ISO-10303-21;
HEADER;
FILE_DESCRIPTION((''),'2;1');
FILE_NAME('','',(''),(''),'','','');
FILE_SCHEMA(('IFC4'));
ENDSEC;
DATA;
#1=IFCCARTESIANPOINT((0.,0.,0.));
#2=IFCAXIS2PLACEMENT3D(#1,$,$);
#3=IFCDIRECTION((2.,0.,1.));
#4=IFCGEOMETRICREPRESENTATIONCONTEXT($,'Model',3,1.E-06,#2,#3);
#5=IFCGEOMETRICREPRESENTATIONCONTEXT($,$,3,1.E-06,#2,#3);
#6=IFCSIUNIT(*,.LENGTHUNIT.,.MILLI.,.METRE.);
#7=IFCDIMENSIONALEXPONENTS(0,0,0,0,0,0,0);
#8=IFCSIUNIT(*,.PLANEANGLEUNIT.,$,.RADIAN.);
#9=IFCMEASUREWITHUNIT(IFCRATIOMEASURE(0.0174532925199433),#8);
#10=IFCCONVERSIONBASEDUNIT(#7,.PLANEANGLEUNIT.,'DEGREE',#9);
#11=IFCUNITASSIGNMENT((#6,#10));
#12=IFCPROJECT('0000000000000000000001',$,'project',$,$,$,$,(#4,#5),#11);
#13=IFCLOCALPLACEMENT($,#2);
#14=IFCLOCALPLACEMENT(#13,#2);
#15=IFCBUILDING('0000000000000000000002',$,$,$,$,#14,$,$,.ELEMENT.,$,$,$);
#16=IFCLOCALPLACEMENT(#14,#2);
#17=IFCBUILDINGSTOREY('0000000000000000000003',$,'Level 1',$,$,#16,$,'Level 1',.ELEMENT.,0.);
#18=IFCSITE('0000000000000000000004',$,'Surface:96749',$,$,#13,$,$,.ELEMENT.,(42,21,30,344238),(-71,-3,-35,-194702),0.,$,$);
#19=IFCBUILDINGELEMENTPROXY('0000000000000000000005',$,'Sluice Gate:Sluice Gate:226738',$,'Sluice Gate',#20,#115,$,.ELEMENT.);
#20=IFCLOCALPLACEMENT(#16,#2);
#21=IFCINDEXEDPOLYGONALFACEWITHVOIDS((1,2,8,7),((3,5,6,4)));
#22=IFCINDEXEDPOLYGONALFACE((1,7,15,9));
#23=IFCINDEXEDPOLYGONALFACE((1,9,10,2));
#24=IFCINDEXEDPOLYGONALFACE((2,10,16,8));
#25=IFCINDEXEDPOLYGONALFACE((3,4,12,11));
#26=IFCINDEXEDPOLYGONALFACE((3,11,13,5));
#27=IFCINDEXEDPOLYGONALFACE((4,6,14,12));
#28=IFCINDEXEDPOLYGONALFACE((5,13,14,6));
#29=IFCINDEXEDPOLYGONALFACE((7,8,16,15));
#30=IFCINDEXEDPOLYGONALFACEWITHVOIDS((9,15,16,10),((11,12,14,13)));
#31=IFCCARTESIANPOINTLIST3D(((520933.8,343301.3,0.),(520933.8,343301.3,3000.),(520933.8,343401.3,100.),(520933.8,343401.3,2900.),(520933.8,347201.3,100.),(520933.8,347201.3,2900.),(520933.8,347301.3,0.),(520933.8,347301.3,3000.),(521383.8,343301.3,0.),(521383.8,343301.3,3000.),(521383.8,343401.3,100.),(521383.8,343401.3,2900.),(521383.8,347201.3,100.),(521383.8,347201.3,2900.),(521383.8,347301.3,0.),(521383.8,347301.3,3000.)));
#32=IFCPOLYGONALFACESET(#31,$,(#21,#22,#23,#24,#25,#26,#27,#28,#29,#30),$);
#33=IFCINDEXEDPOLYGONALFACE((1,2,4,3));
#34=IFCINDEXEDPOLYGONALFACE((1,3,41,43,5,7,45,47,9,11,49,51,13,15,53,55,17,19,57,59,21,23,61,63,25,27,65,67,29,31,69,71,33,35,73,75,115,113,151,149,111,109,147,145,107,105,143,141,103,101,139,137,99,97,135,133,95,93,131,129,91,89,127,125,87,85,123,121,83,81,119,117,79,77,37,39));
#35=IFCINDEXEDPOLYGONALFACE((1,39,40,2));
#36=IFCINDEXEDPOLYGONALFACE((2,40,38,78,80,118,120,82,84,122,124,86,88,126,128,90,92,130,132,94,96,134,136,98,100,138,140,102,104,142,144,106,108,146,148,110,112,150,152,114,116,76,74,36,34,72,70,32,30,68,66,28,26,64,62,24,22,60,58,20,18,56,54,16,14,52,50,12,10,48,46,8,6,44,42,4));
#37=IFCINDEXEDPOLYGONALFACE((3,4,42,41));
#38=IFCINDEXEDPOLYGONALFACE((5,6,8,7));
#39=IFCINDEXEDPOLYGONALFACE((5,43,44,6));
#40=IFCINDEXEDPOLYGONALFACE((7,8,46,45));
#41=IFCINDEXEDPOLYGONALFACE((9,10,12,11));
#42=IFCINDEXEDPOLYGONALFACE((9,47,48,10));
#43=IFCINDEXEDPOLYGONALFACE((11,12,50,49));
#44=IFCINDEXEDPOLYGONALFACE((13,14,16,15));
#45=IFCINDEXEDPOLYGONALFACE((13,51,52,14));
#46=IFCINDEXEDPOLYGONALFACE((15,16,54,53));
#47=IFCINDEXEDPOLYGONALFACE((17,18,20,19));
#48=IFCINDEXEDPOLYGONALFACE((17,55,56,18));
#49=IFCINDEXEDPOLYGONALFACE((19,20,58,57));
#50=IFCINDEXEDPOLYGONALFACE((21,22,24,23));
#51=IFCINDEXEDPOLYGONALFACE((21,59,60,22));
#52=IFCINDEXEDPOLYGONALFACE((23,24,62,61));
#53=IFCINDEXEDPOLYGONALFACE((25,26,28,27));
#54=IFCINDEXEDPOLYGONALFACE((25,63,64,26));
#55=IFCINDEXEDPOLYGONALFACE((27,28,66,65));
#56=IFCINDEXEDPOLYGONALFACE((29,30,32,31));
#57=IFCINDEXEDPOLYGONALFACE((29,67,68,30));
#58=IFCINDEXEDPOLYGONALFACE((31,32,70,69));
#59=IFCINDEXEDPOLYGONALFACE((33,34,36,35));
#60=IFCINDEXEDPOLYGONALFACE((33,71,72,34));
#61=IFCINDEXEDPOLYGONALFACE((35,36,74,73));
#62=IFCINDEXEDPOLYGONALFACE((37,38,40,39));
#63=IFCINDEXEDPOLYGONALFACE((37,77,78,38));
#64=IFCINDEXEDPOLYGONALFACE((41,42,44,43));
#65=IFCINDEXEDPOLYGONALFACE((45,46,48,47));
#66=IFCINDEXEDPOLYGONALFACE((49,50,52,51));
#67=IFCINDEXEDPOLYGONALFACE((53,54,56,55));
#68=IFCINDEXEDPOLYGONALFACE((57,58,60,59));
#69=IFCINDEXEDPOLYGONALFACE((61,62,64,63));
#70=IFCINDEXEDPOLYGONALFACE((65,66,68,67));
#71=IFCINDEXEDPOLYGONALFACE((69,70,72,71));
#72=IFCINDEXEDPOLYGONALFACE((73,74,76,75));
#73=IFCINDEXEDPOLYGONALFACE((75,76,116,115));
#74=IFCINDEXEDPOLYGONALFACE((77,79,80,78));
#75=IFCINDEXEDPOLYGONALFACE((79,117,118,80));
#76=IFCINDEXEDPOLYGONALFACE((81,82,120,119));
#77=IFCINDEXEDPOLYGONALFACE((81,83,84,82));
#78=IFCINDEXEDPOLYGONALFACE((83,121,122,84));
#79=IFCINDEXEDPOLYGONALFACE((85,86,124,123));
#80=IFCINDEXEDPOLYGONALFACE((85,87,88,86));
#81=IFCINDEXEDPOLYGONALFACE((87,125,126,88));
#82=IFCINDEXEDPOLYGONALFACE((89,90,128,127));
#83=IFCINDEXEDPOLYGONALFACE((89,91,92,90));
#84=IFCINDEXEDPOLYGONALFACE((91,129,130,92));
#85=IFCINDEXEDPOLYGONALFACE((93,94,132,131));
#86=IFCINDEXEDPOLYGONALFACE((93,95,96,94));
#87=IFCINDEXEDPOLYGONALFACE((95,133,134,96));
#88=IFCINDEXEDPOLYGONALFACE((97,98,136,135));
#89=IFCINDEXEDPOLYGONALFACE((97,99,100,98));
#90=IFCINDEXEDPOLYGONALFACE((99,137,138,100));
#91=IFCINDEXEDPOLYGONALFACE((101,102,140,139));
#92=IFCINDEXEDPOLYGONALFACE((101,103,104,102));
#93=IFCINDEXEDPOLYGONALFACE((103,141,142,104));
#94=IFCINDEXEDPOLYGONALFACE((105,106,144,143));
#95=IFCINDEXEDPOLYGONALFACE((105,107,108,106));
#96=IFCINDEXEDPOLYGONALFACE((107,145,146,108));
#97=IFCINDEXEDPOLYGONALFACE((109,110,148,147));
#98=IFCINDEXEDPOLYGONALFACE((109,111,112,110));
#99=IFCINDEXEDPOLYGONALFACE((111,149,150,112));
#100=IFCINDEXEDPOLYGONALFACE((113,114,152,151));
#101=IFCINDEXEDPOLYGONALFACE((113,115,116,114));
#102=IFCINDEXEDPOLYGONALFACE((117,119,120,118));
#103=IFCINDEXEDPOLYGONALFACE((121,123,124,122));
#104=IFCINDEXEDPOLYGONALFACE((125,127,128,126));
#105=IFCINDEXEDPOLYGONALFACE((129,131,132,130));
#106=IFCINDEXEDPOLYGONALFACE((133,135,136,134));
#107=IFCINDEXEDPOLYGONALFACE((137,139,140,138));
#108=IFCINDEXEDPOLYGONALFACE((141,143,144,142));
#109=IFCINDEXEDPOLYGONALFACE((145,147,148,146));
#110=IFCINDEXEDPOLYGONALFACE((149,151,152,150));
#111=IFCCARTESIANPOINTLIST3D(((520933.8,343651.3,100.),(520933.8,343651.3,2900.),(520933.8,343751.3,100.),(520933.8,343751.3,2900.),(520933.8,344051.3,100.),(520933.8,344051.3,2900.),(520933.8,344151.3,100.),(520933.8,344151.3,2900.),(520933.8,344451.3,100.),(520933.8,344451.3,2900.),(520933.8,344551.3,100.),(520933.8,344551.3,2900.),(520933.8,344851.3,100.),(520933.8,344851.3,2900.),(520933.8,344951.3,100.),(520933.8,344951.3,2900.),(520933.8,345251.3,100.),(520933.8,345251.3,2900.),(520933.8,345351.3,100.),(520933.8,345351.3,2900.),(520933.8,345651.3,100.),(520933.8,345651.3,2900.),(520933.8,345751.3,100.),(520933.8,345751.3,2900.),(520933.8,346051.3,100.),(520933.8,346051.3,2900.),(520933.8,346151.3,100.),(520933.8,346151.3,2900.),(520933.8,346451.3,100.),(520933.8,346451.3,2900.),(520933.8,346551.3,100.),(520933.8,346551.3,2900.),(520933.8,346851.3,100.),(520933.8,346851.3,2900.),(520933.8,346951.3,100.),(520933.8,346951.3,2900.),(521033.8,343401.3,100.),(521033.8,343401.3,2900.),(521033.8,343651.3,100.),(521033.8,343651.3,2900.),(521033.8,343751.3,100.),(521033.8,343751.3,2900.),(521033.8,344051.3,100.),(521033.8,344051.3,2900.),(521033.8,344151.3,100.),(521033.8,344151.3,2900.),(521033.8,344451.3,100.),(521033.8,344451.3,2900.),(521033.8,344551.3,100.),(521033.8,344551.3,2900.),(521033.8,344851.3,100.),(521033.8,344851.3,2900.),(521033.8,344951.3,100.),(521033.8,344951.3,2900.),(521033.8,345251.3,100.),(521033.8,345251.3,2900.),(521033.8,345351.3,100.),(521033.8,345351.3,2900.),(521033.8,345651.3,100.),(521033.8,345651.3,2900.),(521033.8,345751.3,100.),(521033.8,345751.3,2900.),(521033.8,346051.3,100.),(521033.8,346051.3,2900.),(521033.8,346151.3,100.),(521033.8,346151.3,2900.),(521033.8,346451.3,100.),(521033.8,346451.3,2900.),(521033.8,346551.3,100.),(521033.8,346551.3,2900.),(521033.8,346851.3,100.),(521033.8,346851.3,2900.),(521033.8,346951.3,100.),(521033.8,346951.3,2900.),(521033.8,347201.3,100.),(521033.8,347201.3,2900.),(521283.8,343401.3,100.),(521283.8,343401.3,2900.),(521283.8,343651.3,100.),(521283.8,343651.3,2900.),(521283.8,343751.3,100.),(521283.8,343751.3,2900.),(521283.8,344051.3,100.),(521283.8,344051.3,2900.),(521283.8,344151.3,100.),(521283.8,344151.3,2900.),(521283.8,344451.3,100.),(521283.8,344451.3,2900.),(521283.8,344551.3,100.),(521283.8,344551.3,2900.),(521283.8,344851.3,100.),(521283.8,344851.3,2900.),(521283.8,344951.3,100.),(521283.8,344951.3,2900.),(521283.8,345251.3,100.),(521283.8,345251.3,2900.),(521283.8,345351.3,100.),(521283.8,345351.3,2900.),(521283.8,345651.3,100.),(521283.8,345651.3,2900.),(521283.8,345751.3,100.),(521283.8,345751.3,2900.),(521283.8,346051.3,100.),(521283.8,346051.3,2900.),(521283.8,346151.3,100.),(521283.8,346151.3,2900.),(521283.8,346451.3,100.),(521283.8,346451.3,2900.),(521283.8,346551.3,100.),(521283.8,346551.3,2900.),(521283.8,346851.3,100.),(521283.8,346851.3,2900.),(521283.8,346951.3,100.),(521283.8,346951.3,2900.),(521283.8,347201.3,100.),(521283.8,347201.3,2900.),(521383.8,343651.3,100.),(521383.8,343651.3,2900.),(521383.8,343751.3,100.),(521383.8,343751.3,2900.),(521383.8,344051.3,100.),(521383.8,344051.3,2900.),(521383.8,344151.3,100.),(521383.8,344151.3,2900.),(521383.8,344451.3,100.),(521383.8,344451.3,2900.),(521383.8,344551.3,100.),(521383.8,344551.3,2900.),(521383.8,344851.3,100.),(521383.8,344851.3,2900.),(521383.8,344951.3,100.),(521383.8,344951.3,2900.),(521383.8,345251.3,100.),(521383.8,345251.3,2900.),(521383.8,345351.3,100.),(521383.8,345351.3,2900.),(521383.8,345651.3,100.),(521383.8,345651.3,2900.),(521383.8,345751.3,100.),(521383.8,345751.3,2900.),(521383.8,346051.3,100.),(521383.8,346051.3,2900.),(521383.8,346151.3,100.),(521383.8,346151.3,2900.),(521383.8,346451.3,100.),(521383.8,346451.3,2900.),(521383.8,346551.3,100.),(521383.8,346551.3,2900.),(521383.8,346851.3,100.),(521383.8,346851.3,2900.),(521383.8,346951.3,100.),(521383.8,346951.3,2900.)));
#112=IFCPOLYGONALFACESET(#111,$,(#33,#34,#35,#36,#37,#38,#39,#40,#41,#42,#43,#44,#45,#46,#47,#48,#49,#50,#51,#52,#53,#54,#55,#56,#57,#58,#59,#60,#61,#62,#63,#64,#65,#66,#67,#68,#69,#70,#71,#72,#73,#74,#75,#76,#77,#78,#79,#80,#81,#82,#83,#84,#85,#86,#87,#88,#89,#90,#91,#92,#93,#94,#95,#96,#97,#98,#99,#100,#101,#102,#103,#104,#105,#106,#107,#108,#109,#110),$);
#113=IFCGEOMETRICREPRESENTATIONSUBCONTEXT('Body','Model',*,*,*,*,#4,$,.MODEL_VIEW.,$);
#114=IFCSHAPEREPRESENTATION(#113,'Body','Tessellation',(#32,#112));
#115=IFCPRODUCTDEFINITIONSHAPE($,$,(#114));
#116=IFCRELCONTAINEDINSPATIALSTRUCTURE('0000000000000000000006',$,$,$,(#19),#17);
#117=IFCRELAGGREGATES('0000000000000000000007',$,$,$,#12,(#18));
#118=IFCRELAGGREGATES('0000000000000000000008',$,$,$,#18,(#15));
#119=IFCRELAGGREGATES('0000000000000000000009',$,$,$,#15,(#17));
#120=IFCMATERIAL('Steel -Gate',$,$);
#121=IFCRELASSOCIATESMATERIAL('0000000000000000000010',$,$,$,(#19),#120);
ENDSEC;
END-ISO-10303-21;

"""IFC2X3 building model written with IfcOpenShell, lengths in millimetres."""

from ifc_helpers import new_model, entity, si_unit, converted_unit, direction, frame, origin, place, context, subcontext, project, spatial, polyline, outline, extrude, source, transform, mapped, material, element, save


model = new_model("IFC2X3")

# Units and contexts
model_context = context("Model", 3, precision=1e-06, world=origin(), true_north=direction((2.0, 0.0, 1.0)))
context_of_model = context(None, 3, precision=1e-06, world=origin(), true_north=direction((2.0, 0.0, 1.0)))
body_context = subcontext(model_context, "Body", "Model", "MODEL_VIEW")
ifc_project = project(units=[si_unit("LENGTHUNIT", "METRE", prefix="MILLI"), converted_unit("PLANEANGLEUNIT", "DEGREE", entity("IfcRatioMeasure", 0.0174532925199433), si_unit("PLANEANGLEUNIT", "RADIAN"), dimensions=[0, 0, 0, 0, 0, 0, 0])], contexts=[model_context, context_of_model])

# Site, building, storey
site_placement = place(None, origin())
site = spatial("IfcSite", under=ifc_project, at=site_placement, Name="Surface:96749", CompositionType="ELEMENT", RefLatitude=(42, 21, 30, 344238), RefLongitude=(-71, -3, -35, -194702), RefElevation=0.0)
building_placement = place(site_placement, origin())
building = spatial("IfcBuilding", under=site, at=building_placement, CompositionType="ELEMENT")
storey_placement = place(building_placement, origin())
storey = spatial("IfcBuildingStorey", under=building, at=storey_placement, Name="Level 1", LongName="Level 1", CompositionType="ELEMENT", Elevation=0.0)

# Building element proxy
ifc_material = material(Name="Steel -Gate")
shared_shape_1 = source(origin(), body_context, "Body", "SweptSolid", [
    extrude(outline(polyline([(-1500.0, -2000.0), (1500.0, -2000.0), (1500.0, 2000.0), (-1500.0, 2000.0), (-1500.0, -2000.0)]), holes=[polyline([(1400.0, -1900.0), (-1400.0, -1900.0), (-1400.0, 1900.0), (1400.0, 1900.0), (1400.0, -1900.0)])]), frame((0.0, -225.0, 1500.0), z_axis=(0.0, 1.0, 0.0), x_axis=(0.0, 0.0, -1.0)), (0.0, 0.0, 1.0), 450.0),
    extrude(outline(polyline([(1650.0, -125.0), (1900.0, -125.0), (1900.0, 125.0), (1650.0, 125.0), (1650.0, 225.0), (1550.0, 225.0), (1550.0, 125.0), (1250.0, 125.0), (1250.0, 225.0), (1150.0, 225.0), (1150.0, 125.0), (850.0, 125.0), (850.0, 225.0), (750.0, 225.0), (750.0, 125.0), (450.0, 125.0), (450.0, 225.0), (350.0, 225.0), (350.0, 125.0), (50.0, 125.0), (50.0, 225.0), (-50.0, 225.0), (-50.0, 125.0), (-350.0, 125.0), (-350.0, 225.0), (-450.0, 225.0), (-450.0, 125.0), (-750.0, 125.0), (-750.0, 225.0), (-850.0, 225.0), (-850.0, 125.0), (-1150.0, 125.0), (-1150.0, 225.0), (-1250.0, 225.0), (-1250.0, 125.0), (-1550.0, 125.0), (-1550.0, 225.0), (-1650.0, 225.0), (-1650.0, 125.0), (-1900.0, 125.0), (-1900.0, -125.0), (-1650.0, -125.0), (-1650.0, -225.0), (-1550.0, -225.0), (-1550.0, -125.0), (-1250.0, -125.0), (-1250.0, -225.0), (-1150.0, -225.0), (-1150.0, -125.0), (-850.0, -125.0), (-850.0, -225.0), (-750.0, -225.0), (-750.0, -125.0), (-450.0, -125.0), (-450.0, -225.0), (-350.0, -225.0), (-350.0, -125.0), (-50.0, -125.0), (-50.0, -225.0), (50.0, -225.0), (50.0, -125.0), (350.0, -125.0), (350.0, -225.0), (450.0, -225.0), (450.0, -125.0), (750.0, -125.0), (750.0, -225.0), (850.0, -225.0), (850.0, -125.0), (1150.0, -125.0), (1150.0, -225.0), (1250.0, -225.0), (1250.0, -125.0), (1550.0, -125.0), (1550.0, -225.0), (1650.0, -225.0), (1650.0, -125.0)])), frame((0.0, 0.0, 100.0), z_axis=(0.0, 0.0, 1.0), x_axis=(-1.0, 0.0, 0.0)), (0.0, 0.0, 1.0), 2800.0),
])
for number, where, z_axis, x_axis, name in (
    (1, (521158.8, 345301.3, 0.0), (0.0, 0.0, 1.0), (0.0, 1.0, 0.0), "Sluice Gate:Sluice Gate:226738"),
):
    element("IfcBuildingElementProxy", number, at=place(storey_placement, frame(where, z_axis=z_axis, x_axis=x_axis)), inside=storey, material=ifc_material, Name=name, ObjectType="Sluice Gate", CompositionType="ELEMENT", context=body_context, shape_type="MappedRepresentation", body=[
        mapped(shared_shape_1, transform((0.0, 0.0, 0.0), scale=1.0)),
    ])

save(model, "model.ifc")
